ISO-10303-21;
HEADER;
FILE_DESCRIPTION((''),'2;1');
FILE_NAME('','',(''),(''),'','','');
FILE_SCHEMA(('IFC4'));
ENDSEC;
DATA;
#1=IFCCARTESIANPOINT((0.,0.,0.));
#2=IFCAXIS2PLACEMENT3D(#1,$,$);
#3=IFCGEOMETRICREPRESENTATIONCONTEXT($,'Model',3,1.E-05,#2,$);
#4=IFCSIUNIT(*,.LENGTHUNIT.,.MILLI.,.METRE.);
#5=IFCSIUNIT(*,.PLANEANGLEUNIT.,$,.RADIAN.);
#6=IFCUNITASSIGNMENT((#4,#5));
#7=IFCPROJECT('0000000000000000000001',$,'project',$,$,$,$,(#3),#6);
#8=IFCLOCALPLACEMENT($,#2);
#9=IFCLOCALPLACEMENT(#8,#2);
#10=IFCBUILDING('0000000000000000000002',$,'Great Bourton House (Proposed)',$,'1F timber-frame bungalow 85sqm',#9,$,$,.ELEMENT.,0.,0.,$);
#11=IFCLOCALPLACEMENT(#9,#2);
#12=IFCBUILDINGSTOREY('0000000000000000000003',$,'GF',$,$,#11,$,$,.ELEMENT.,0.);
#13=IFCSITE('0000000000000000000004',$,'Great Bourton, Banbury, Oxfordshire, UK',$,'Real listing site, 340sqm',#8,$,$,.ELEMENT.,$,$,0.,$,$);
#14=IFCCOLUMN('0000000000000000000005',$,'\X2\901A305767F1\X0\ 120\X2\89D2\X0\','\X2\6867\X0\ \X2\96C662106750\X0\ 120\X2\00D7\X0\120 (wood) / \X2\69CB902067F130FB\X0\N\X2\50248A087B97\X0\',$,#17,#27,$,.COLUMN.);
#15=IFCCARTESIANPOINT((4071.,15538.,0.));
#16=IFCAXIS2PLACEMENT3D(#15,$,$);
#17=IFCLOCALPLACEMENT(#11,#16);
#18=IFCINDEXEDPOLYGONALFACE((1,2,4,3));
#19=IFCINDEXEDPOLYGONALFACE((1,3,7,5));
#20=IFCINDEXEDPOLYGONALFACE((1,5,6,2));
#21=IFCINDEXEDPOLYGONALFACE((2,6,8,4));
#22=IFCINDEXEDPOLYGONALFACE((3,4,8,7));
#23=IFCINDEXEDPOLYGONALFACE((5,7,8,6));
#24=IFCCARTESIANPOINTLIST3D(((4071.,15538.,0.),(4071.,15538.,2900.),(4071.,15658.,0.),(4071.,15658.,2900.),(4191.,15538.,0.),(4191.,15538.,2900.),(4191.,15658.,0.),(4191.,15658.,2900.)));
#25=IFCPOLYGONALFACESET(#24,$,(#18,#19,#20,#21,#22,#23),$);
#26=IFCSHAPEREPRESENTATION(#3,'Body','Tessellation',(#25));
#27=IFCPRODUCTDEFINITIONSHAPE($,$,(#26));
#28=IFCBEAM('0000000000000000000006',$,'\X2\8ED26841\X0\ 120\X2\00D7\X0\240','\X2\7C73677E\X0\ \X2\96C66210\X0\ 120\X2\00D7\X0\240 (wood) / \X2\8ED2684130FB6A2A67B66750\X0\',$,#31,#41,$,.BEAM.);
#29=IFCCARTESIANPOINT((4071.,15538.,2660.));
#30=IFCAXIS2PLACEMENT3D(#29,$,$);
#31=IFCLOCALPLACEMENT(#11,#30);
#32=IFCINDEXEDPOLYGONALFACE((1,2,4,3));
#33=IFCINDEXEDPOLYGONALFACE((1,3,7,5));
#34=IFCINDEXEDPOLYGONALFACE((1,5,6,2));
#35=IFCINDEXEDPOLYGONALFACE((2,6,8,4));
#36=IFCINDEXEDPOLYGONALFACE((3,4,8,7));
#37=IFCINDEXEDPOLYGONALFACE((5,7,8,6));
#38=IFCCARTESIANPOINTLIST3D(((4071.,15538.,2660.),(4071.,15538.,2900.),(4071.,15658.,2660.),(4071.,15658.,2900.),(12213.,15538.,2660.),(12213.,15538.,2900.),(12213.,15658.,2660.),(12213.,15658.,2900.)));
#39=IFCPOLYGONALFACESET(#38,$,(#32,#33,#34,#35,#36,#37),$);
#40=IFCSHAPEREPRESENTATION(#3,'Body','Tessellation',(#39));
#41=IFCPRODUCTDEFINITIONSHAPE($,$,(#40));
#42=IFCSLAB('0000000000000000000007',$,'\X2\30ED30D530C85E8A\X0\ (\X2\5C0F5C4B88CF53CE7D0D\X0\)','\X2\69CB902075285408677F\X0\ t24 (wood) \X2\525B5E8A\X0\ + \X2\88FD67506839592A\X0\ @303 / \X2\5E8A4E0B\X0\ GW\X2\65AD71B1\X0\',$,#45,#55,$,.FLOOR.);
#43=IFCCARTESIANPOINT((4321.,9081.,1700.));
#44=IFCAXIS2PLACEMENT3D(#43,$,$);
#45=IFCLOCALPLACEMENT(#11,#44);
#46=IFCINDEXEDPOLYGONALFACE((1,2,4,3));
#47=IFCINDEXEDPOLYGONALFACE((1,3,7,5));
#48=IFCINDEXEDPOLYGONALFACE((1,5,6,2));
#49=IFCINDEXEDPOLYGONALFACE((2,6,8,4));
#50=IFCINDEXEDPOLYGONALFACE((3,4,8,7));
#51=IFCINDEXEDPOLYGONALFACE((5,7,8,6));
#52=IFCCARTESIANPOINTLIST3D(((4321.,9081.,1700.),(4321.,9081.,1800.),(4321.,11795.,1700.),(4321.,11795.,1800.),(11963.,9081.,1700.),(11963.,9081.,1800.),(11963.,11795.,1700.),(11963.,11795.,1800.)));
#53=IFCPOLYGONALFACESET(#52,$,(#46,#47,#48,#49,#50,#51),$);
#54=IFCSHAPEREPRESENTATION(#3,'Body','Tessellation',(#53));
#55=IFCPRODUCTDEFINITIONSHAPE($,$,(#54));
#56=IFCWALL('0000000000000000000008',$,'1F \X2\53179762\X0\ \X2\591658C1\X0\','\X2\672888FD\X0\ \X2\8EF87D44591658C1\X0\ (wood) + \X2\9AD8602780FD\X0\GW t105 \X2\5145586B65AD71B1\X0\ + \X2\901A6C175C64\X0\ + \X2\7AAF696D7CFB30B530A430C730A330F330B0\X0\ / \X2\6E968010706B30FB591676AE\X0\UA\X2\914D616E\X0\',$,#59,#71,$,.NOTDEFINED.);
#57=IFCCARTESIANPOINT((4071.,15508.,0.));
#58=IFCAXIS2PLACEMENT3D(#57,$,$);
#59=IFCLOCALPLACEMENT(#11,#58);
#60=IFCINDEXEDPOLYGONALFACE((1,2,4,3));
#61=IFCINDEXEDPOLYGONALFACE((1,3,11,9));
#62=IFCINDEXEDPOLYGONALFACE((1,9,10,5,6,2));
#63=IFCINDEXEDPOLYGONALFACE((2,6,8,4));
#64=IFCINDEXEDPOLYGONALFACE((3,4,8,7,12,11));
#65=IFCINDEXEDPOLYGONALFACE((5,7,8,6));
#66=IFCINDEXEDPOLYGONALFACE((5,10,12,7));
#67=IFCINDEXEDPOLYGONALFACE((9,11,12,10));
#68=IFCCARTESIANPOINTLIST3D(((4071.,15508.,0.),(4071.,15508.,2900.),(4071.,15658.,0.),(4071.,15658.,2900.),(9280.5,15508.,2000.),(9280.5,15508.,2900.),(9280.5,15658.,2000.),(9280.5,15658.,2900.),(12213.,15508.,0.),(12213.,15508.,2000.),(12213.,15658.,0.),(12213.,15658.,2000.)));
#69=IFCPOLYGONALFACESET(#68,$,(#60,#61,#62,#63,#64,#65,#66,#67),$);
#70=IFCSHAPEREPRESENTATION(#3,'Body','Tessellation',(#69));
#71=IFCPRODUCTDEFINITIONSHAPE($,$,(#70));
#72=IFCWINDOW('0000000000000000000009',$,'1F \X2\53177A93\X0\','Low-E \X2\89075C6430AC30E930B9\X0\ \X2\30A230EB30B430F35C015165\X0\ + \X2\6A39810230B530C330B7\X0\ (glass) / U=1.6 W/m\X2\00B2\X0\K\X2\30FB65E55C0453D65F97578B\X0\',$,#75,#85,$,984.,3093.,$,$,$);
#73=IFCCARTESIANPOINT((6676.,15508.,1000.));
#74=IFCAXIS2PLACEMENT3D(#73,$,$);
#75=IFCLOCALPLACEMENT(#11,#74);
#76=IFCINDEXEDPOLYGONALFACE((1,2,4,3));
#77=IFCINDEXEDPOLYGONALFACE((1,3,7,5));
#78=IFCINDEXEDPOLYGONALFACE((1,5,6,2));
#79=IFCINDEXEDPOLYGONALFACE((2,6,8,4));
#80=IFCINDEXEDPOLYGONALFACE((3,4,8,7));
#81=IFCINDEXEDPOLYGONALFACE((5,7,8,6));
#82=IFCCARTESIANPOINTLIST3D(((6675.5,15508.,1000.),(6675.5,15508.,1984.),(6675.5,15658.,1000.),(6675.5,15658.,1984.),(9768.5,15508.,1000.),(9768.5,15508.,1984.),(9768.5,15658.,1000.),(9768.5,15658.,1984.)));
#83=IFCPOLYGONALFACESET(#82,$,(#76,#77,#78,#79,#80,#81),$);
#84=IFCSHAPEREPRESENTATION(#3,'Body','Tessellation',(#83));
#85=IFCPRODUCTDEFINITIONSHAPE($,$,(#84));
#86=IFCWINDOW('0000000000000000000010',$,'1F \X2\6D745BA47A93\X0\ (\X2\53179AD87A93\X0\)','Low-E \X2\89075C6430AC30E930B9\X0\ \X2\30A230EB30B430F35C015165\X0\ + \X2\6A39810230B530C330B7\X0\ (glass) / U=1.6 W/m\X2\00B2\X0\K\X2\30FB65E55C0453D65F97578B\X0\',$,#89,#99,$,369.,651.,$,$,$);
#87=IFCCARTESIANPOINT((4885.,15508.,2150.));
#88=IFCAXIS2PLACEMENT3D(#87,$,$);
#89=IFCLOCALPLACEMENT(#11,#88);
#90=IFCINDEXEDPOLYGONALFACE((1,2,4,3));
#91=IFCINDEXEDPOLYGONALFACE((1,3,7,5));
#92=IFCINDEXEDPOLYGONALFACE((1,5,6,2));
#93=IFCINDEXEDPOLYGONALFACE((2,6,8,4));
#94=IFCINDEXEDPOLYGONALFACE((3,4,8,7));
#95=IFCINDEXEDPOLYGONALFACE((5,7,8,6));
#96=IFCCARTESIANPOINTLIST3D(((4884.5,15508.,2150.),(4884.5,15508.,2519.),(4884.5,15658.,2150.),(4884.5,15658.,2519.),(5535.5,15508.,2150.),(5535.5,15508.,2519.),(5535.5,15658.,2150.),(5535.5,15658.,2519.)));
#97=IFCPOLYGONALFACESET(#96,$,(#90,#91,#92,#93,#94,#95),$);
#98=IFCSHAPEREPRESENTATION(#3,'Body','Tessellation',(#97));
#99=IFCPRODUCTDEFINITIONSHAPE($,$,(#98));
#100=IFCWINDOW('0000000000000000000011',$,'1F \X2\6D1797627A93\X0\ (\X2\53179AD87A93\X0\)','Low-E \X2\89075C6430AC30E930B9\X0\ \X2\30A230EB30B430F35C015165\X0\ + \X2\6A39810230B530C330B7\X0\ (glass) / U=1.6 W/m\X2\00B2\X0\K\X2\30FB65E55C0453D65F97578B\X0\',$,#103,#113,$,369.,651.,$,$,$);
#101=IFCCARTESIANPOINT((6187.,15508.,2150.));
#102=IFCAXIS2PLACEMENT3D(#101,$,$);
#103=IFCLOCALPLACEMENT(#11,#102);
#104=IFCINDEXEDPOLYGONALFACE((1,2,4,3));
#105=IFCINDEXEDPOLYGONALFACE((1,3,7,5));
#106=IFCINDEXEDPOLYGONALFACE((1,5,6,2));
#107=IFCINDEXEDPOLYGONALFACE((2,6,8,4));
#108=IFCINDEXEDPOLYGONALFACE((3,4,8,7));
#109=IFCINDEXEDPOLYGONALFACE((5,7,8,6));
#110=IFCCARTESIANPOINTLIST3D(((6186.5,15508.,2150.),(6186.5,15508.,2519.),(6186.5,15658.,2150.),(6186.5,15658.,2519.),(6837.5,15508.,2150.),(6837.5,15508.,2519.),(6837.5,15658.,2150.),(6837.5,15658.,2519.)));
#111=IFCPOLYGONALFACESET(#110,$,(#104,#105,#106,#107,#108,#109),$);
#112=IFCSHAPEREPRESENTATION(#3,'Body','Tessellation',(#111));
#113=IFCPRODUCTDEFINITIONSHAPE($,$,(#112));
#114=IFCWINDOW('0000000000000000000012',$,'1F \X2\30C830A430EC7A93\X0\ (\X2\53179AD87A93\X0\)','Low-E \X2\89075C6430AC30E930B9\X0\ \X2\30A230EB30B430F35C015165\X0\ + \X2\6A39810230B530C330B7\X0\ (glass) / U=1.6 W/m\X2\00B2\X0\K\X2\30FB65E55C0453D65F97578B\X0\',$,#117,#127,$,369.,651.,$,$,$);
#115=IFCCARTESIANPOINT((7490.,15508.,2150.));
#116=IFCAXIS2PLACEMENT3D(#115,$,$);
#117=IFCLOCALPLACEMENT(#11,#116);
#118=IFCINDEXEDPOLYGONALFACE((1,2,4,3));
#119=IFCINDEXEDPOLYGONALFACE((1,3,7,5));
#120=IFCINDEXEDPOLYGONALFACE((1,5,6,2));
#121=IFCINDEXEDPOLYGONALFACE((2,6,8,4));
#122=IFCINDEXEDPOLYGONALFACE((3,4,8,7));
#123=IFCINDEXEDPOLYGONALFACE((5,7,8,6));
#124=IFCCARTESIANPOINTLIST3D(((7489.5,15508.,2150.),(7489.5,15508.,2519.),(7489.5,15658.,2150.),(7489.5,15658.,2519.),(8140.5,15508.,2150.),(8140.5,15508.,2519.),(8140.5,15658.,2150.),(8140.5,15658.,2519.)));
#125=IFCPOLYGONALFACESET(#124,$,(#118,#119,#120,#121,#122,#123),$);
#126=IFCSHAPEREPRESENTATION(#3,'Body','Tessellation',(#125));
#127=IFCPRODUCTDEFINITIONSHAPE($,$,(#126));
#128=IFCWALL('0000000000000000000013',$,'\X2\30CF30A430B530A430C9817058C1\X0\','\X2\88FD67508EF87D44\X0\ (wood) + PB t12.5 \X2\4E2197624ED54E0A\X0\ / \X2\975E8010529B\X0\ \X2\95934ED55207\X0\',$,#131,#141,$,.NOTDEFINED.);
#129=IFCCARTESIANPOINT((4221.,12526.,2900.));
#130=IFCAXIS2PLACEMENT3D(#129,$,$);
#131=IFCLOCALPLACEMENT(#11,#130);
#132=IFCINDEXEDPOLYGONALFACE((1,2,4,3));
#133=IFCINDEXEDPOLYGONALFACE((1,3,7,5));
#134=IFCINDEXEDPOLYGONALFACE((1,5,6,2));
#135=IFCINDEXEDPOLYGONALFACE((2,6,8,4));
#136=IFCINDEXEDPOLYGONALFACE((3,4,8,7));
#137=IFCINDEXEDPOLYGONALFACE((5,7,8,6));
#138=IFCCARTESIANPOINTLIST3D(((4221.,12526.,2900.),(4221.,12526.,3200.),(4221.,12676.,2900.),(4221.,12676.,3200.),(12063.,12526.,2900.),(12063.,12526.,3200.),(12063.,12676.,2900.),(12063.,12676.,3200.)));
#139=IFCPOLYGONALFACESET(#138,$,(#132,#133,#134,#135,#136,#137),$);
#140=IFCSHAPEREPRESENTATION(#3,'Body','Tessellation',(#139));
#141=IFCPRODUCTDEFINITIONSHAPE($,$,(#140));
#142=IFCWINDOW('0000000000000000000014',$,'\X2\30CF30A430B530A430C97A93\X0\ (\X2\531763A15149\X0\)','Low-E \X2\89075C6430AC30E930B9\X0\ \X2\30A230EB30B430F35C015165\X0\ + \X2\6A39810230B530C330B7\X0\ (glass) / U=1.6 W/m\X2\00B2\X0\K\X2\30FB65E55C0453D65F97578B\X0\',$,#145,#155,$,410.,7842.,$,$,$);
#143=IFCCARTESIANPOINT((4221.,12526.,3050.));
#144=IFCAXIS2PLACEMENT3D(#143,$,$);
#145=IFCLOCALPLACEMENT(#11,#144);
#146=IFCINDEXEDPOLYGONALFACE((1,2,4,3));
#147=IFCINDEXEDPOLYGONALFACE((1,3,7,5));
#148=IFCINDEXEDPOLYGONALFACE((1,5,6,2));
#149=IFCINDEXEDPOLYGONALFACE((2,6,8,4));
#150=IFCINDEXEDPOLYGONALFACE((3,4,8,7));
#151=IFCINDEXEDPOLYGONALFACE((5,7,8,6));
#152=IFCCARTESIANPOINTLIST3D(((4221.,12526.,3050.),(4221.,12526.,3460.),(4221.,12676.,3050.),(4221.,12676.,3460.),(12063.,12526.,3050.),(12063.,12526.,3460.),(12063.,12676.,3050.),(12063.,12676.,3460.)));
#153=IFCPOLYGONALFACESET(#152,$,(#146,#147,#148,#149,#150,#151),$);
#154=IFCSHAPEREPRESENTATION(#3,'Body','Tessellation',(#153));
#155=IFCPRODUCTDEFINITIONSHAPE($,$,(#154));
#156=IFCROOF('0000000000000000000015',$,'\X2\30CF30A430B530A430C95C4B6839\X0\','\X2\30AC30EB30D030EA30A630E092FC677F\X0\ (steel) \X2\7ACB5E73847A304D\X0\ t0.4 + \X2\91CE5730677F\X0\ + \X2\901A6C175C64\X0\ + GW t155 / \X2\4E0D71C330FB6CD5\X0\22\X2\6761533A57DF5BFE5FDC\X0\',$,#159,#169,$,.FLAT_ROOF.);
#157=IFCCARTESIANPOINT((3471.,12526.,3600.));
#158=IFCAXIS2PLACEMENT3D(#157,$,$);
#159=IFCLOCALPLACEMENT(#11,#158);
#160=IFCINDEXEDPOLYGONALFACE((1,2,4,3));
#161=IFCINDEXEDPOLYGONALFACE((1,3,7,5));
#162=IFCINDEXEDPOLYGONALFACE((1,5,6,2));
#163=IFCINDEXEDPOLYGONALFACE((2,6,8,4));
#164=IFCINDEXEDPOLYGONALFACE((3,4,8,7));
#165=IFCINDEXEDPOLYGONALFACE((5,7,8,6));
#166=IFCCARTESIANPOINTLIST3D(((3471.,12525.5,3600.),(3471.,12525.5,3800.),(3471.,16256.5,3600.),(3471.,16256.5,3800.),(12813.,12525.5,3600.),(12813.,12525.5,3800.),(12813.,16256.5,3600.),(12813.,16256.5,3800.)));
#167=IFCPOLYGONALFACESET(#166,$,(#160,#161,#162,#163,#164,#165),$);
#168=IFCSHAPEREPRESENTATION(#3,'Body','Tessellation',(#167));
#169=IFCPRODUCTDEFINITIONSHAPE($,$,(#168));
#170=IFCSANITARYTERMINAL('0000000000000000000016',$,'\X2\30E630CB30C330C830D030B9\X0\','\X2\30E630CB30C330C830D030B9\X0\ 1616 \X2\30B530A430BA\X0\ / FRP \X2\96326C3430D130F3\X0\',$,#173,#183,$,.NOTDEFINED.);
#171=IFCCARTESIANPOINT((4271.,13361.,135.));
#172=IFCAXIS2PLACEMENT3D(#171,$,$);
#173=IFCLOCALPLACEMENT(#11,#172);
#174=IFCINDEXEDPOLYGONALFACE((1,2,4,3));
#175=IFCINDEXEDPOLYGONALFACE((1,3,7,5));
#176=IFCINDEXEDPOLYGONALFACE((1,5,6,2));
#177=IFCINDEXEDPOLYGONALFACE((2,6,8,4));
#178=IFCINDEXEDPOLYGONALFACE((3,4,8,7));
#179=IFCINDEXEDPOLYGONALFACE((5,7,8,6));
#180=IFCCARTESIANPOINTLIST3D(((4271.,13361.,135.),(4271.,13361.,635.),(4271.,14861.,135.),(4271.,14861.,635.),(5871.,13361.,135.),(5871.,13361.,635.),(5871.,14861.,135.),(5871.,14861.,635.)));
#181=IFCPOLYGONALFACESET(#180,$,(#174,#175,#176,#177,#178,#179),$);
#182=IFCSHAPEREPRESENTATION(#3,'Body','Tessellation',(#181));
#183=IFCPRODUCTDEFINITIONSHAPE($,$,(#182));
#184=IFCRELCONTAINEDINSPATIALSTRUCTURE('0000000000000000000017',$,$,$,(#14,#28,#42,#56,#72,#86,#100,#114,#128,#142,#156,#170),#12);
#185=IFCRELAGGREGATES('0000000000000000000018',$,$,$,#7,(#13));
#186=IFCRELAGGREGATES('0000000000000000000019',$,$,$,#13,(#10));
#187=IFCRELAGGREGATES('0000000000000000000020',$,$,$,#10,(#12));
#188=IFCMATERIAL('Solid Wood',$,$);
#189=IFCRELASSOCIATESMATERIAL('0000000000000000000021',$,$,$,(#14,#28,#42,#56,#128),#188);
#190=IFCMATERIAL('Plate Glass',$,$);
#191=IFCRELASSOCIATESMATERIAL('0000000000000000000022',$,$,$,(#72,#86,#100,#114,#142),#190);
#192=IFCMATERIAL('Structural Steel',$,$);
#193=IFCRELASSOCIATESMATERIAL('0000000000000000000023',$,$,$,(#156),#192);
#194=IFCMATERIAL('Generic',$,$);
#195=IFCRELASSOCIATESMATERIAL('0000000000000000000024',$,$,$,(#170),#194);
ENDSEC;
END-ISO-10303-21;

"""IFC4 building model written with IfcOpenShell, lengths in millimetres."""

from ifc_helpers import new_model, si_unit, frame, frame_2d, origin, place, context, project, spatial, rectangle, extrude, material, element, fill, save


model = new_model("IFC4")

# Units and contexts
model_context = context("Model", 3, precision=1e-05, world=origin())
ifc_project = project(units=[si_unit("LENGTHUNIT", "METRE", prefix="MILLI"), si_unit("PLANEANGLEUNIT", "RADIAN")], contexts=[model_context])

# Site, building, storey
site_placement = place(None, origin())
site = spatial("IfcSite", under=ifc_project, at=site_placement, Name="Great Bourton, Banbury, Oxfordshire, UK", ObjectType="Real listing site, 340sqm", CompositionType="ELEMENT", RefElevation=0.0)
building_placement = place(site_placement, origin())
building = spatial("IfcBuilding", under=site, at=building_placement, Name="Great Bourton House (Proposed)", ObjectType="1F timber-frame bungalow 85sqm", CompositionType="ELEMENT", ElevationOfRefHeight=0.0, ElevationOfTerrain=0.0)
storey_placement = place(building_placement, origin())
storey = spatial("IfcBuildingStorey", under=building, at=storey_placement, Name="GF", CompositionType="ELEMENT", Elevation=0.0)

# Column
ifc_material_1 = material(Name="Solid Wood")
column_1_placement = place(storey_placement, frame((4071.0, 15538.0, 0.0)))
element("IfcColumn", 1, at=column_1_placement, inside=storey, material=ifc_material_1, Name="通し柱 120角", Description="桧 集成材 120×120 (wood) / 構造柱・N値計算", PredefinedType="COLUMN", context=model_context, shape_type="SweptSolid", body=[
    extrude(rectangle(XDim=120.0, YDim=120.0, at=frame_2d((60.0, 60.0))), frame((4071.0, 15538.0, 0.0)), (0.0, 0.0, 1.0), 2900.0),
])

# Beam
beam_1_placement = place(storey_placement, frame((4071.0, 15538.0, 2660.0)))
element("IfcBeam", 2, at=beam_1_placement, inside=storey, material=ifc_material_1, Name="軒桁 120×240", Description="米松 集成 120×240 (wood) / 軒桁・横架材", PredefinedType="BEAM", context=model_context, shape_type="SweptSolid", body=[
    extrude(rectangle(XDim=8142.0, YDim=120.0, at=frame_2d((4071.0, 60.0))), frame((4071.0, 15538.0, 2660.0)), (0.0, 0.0, 1.0), 240.0),
])

# Slab
slab_placement = place(storey_placement, frame((4321.0, 9081.0, 1700.0)))
element("IfcSlab", 3, at=slab_placement, inside=storey, material=ifc_material_1, Name="ロフト床 (小屋裏収納)", Description="構造用合板 t24 (wood) 剛床 + 製材根太 @303 / 床下 GW断熱", PredefinedType="FLOOR", context=model_context, shape_type="SweptSolid", body=[
    extrude(rectangle(XDim=7642.0, YDim=2714.0, at=frame_2d((3821.0, 1357.0))), frame((4321.0, 9081.0, 1700.0)), (0.0, 0.0, 1.0), 100.0),
])

# Wall, openings, windows
wall_1_placement = place(storey_placement, frame((4071.0, 15508.0, 0.0)))
wall_1 = element("IfcWall", 4, at=wall_1_placement, inside=storey, material=ifc_material_1, Name="1F 北面 外壁", Description="木製 軸組外壁 (wood) + 高性能GW t105 充填断熱 + 通気層 + 窯業系サイディング / 準耐火・外皮UA配慮", PredefinedType="NOTDEFINED", context=model_context, shape_type="SweptSolid", body=[
    extrude(rectangle(XDim=8142.0, YDim=150.0, at=frame_2d((4071.0, 75.0))), frame((4071.0, 15508.0, 0.0)), (0.0, 0.0, 1.0), 2900.0),
])
opening_1_placement = place(storey_placement, frame((6676.0, 15508.0, 1000.0)))
opening_1 = element("IfcOpeningElement", 5, at=opening_1_placement, cuts=wall_1, PredefinedType="NOTDEFINED", context=model_context, shape_type="SweptSolid", body=[
    extrude(rectangle(XDim=3093.0, YDim=150.0, at=frame_2d((1546.0, 75.0))), frame((6676.0, 15508.0, 1000.0)), (0.0, 0.0, 1.0), 984.0),
])
opening_2_placement = place(storey_placement, frame((4885.0, 15508.0, 2150.0)))
opening_2 = element("IfcOpeningElement", 6, at=opening_2_placement, cuts=wall_1, PredefinedType="NOTDEFINED", context=model_context, shape_type="SweptSolid", body=[
    extrude(rectangle(XDim=651.0, YDim=150.0, at=frame_2d((325.0, 75.0))), frame((4885.0, 15508.0, 2150.0)), (0.0, 0.0, 1.0), 369.0),
])
opening_3_placement = place(storey_placement, frame((6187.0, 15508.0, 2150.0)))
opening_3 = element("IfcOpeningElement", 7, at=opening_3_placement, cuts=wall_1, PredefinedType="NOTDEFINED", context=model_context, shape_type="SweptSolid", body=[
    extrude(rectangle(XDim=651.0, YDim=150.0, at=frame_2d((325.0, 75.0))), frame((6187.0, 15508.0, 2150.0)), (0.0, 0.0, 1.0), 369.0),
])
opening_4_placement = place(storey_placement, frame((7490.0, 15508.0, 2150.0)))
opening_4 = element("IfcOpeningElement", 8, at=opening_4_placement, cuts=wall_1, PredefinedType="NOTDEFINED", context=model_context, shape_type="SweptSolid", body=[
    extrude(rectangle(XDim=651.0, YDim=150.0, at=frame_2d((325.0, 75.0))), frame((7490.0, 15508.0, 2150.0)), (0.0, 0.0, 1.0), 369.0),
])
ifc_material_2 = material(Name="Plate Glass")
window_1_placement = place(storey_placement, frame((6676.0, 15508.0, 1000.0)))
window_1 = element("IfcWindow", 9, at=window_1_placement, inside=storey, material=ifc_material_2, Name="1F 北窓", Description="Low-E 複層ガラス アルゴン封入 + 樹脂サッシ (glass) / U=1.6 W/m²K・日射取得型", OverallHeight=984.0, OverallWidth=3093.0, context=model_context, shape_type="SweptSolid", body=[
    extrude(rectangle(XDim=3093.0, YDim=150.0, at=frame_2d((1546.0, 75.0))), frame((6676.0, 15508.0, 1000.0)), (0.0, 0.0, 1.0), 984.0),
])
fill(opening_1, window_1)
window_2_placement = place(storey_placement, frame((4885.0, 15508.0, 2150.0)))
window_2 = element("IfcWindow", 10, at=window_2_placement, inside=storey, material=ifc_material_2, Name="1F 浴室窓 (北高窓)", Description="Low-E 複層ガラス アルゴン封入 + 樹脂サッシ (glass) / U=1.6 W/m²K・日射取得型", OverallHeight=369.0, OverallWidth=651.0, context=model_context, shape_type="SweptSolid", body=[
    extrude(rectangle(XDim=651.0, YDim=150.0, at=frame_2d((325.0, 75.0))), frame((4885.0, 15508.0, 2150.0)), (0.0, 0.0, 1.0), 369.0),
])
fill(opening_2, window_2)
window_3_placement = place(storey_placement, frame((6187.0, 15508.0, 2150.0)))
window_3 = element("IfcWindow", 11, at=window_3_placement, inside=storey, material=ifc_material_2, Name="1F 洗面窓 (北高窓)", Description="Low-E 複層ガラス アルゴン封入 + 樹脂サッシ (glass) / U=1.6 W/m²K・日射取得型", OverallHeight=369.0, OverallWidth=651.0, context=model_context, shape_type="SweptSolid", body=[
    extrude(rectangle(XDim=651.0, YDim=150.0, at=frame_2d((325.0, 75.0))), frame((6187.0, 15508.0, 2150.0)), (0.0, 0.0, 1.0), 369.0),
])
fill(opening_3, window_3)
window_4_placement = place(storey_placement, frame((7490.0, 15508.0, 2150.0)))
window_4 = element("IfcWindow", 12, at=window_4_placement, inside=storey, material=ifc_material_2, Name="1F トイレ窓 (北高窓)", Description="Low-E 複層ガラス アルゴン封入 + 樹脂サッシ (glass) / U=1.6 W/m²K・日射取得型", OverallHeight=369.0, OverallWidth=651.0, context=model_context, shape_type="SweptSolid", body=[
    extrude(rectangle(XDim=651.0, YDim=150.0, at=frame_2d((325.0, 75.0))), frame((7490.0, 15508.0, 2150.0)), (0.0, 0.0, 1.0), 369.0),
])
fill(opening_4, window_4)

# Wall, opening, window
wall_2_placement = place(storey_placement, frame((4221.0, 12526.0, 2900.0)))
wall_2 = element("IfcWall", 13, at=wall_2_placement, inside=storey, material=ifc_material_1, Name="ハイサイド腰壁", Description="製材軸組 (wood) + PB t12.5 両面仕上 / 非耐力 間仕切", PredefinedType="NOTDEFINED", context=model_context, shape_type="SweptSolid", body=[
    extrude(rectangle(XDim=7842.0, YDim=150.0, at=frame_2d((3921.0, 75.0))), frame((4221.0, 12526.0, 2900.0)), (0.0, 0.0, 1.0), 700.0),
])
opening_5_placement = place(storey_placement, frame((4221.0, 12526.0, 3050.0)))
opening_5 = element("IfcOpeningElement", 14, at=opening_5_placement, cuts=wall_2, PredefinedType="NOTDEFINED", context=model_context, shape_type="SweptSolid", body=[
    extrude(rectangle(XDim=7842.0, YDim=150.0, at=frame_2d((3921.0, 75.0))), frame((4221.0, 12526.0, 3050.0)), (0.0, 0.0, 1.0), 410.0),
])
window_5_placement = place(storey_placement, frame((4221.0, 12526.0, 3050.0)))
window_5 = element("IfcWindow", 15, at=window_5_placement, inside=storey, material=ifc_material_2, Name="ハイサイド窓 (北採光)", Description="Low-E 複層ガラス アルゴン封入 + 樹脂サッシ (glass) / U=1.6 W/m²K・日射取得型", OverallHeight=410.0, OverallWidth=7842.0, context=model_context, shape_type="SweptSolid", body=[
    extrude(rectangle(XDim=7842.0, YDim=150.0, at=frame_2d((3921.0, 75.0))), frame((4221.0, 12526.0, 3050.0)), (0.0, 0.0, 1.0), 410.0),
])
fill(opening_5, window_5)

# Roof
ifc_material_3 = material(Name="Structural Steel")
roof_placement = place(storey_placement, frame((3471.0, 12526.0, 3600.0)))
element("IfcRoof", 16, at=roof_placement, inside=storey, material=ifc_material_3, Name="ハイサイド屋根", Description="ガルバリウム鋼板 (steel) 立平葺き t0.4 + 野地板 + 通気層 + GW t155 / 不燃・法22条区域対応", PredefinedType="FLAT_ROOF", context=model_context, shape_type="SweptSolid", body=[
    extrude(rectangle(XDim=9342.0, YDim=3731.0, at=frame_2d((4671.0, 1865.0))), frame((3471.0, 12526.0, 3600.0)), (0.0, 0.0, 1.0), 200.0),
])

# Sanitary terminal
ifc_material_4 = material(Name="Generic")
sanitary_terminal_placement = place(storey_placement, frame((4271.0, 13361.0, 135.0)))
element("IfcSanitaryTerminal", 17, at=sanitary_terminal_placement, inside=storey, material=ifc_material_4, Name="ユニットバス", Description="ユニットバス 1616 サイズ / FRP 防水パン", PredefinedType="NOTDEFINED", context=model_context, shape_type="SweptSolid", body=[
    extrude(rectangle(XDim=1600.0, YDim=1500.0, at=frame_2d((800.0, 750.0))), frame((4271.0, 13361.0, 135.0)), (0.0, 0.0, 1.0), 500.0),
])

save(model, "model.ifc")
